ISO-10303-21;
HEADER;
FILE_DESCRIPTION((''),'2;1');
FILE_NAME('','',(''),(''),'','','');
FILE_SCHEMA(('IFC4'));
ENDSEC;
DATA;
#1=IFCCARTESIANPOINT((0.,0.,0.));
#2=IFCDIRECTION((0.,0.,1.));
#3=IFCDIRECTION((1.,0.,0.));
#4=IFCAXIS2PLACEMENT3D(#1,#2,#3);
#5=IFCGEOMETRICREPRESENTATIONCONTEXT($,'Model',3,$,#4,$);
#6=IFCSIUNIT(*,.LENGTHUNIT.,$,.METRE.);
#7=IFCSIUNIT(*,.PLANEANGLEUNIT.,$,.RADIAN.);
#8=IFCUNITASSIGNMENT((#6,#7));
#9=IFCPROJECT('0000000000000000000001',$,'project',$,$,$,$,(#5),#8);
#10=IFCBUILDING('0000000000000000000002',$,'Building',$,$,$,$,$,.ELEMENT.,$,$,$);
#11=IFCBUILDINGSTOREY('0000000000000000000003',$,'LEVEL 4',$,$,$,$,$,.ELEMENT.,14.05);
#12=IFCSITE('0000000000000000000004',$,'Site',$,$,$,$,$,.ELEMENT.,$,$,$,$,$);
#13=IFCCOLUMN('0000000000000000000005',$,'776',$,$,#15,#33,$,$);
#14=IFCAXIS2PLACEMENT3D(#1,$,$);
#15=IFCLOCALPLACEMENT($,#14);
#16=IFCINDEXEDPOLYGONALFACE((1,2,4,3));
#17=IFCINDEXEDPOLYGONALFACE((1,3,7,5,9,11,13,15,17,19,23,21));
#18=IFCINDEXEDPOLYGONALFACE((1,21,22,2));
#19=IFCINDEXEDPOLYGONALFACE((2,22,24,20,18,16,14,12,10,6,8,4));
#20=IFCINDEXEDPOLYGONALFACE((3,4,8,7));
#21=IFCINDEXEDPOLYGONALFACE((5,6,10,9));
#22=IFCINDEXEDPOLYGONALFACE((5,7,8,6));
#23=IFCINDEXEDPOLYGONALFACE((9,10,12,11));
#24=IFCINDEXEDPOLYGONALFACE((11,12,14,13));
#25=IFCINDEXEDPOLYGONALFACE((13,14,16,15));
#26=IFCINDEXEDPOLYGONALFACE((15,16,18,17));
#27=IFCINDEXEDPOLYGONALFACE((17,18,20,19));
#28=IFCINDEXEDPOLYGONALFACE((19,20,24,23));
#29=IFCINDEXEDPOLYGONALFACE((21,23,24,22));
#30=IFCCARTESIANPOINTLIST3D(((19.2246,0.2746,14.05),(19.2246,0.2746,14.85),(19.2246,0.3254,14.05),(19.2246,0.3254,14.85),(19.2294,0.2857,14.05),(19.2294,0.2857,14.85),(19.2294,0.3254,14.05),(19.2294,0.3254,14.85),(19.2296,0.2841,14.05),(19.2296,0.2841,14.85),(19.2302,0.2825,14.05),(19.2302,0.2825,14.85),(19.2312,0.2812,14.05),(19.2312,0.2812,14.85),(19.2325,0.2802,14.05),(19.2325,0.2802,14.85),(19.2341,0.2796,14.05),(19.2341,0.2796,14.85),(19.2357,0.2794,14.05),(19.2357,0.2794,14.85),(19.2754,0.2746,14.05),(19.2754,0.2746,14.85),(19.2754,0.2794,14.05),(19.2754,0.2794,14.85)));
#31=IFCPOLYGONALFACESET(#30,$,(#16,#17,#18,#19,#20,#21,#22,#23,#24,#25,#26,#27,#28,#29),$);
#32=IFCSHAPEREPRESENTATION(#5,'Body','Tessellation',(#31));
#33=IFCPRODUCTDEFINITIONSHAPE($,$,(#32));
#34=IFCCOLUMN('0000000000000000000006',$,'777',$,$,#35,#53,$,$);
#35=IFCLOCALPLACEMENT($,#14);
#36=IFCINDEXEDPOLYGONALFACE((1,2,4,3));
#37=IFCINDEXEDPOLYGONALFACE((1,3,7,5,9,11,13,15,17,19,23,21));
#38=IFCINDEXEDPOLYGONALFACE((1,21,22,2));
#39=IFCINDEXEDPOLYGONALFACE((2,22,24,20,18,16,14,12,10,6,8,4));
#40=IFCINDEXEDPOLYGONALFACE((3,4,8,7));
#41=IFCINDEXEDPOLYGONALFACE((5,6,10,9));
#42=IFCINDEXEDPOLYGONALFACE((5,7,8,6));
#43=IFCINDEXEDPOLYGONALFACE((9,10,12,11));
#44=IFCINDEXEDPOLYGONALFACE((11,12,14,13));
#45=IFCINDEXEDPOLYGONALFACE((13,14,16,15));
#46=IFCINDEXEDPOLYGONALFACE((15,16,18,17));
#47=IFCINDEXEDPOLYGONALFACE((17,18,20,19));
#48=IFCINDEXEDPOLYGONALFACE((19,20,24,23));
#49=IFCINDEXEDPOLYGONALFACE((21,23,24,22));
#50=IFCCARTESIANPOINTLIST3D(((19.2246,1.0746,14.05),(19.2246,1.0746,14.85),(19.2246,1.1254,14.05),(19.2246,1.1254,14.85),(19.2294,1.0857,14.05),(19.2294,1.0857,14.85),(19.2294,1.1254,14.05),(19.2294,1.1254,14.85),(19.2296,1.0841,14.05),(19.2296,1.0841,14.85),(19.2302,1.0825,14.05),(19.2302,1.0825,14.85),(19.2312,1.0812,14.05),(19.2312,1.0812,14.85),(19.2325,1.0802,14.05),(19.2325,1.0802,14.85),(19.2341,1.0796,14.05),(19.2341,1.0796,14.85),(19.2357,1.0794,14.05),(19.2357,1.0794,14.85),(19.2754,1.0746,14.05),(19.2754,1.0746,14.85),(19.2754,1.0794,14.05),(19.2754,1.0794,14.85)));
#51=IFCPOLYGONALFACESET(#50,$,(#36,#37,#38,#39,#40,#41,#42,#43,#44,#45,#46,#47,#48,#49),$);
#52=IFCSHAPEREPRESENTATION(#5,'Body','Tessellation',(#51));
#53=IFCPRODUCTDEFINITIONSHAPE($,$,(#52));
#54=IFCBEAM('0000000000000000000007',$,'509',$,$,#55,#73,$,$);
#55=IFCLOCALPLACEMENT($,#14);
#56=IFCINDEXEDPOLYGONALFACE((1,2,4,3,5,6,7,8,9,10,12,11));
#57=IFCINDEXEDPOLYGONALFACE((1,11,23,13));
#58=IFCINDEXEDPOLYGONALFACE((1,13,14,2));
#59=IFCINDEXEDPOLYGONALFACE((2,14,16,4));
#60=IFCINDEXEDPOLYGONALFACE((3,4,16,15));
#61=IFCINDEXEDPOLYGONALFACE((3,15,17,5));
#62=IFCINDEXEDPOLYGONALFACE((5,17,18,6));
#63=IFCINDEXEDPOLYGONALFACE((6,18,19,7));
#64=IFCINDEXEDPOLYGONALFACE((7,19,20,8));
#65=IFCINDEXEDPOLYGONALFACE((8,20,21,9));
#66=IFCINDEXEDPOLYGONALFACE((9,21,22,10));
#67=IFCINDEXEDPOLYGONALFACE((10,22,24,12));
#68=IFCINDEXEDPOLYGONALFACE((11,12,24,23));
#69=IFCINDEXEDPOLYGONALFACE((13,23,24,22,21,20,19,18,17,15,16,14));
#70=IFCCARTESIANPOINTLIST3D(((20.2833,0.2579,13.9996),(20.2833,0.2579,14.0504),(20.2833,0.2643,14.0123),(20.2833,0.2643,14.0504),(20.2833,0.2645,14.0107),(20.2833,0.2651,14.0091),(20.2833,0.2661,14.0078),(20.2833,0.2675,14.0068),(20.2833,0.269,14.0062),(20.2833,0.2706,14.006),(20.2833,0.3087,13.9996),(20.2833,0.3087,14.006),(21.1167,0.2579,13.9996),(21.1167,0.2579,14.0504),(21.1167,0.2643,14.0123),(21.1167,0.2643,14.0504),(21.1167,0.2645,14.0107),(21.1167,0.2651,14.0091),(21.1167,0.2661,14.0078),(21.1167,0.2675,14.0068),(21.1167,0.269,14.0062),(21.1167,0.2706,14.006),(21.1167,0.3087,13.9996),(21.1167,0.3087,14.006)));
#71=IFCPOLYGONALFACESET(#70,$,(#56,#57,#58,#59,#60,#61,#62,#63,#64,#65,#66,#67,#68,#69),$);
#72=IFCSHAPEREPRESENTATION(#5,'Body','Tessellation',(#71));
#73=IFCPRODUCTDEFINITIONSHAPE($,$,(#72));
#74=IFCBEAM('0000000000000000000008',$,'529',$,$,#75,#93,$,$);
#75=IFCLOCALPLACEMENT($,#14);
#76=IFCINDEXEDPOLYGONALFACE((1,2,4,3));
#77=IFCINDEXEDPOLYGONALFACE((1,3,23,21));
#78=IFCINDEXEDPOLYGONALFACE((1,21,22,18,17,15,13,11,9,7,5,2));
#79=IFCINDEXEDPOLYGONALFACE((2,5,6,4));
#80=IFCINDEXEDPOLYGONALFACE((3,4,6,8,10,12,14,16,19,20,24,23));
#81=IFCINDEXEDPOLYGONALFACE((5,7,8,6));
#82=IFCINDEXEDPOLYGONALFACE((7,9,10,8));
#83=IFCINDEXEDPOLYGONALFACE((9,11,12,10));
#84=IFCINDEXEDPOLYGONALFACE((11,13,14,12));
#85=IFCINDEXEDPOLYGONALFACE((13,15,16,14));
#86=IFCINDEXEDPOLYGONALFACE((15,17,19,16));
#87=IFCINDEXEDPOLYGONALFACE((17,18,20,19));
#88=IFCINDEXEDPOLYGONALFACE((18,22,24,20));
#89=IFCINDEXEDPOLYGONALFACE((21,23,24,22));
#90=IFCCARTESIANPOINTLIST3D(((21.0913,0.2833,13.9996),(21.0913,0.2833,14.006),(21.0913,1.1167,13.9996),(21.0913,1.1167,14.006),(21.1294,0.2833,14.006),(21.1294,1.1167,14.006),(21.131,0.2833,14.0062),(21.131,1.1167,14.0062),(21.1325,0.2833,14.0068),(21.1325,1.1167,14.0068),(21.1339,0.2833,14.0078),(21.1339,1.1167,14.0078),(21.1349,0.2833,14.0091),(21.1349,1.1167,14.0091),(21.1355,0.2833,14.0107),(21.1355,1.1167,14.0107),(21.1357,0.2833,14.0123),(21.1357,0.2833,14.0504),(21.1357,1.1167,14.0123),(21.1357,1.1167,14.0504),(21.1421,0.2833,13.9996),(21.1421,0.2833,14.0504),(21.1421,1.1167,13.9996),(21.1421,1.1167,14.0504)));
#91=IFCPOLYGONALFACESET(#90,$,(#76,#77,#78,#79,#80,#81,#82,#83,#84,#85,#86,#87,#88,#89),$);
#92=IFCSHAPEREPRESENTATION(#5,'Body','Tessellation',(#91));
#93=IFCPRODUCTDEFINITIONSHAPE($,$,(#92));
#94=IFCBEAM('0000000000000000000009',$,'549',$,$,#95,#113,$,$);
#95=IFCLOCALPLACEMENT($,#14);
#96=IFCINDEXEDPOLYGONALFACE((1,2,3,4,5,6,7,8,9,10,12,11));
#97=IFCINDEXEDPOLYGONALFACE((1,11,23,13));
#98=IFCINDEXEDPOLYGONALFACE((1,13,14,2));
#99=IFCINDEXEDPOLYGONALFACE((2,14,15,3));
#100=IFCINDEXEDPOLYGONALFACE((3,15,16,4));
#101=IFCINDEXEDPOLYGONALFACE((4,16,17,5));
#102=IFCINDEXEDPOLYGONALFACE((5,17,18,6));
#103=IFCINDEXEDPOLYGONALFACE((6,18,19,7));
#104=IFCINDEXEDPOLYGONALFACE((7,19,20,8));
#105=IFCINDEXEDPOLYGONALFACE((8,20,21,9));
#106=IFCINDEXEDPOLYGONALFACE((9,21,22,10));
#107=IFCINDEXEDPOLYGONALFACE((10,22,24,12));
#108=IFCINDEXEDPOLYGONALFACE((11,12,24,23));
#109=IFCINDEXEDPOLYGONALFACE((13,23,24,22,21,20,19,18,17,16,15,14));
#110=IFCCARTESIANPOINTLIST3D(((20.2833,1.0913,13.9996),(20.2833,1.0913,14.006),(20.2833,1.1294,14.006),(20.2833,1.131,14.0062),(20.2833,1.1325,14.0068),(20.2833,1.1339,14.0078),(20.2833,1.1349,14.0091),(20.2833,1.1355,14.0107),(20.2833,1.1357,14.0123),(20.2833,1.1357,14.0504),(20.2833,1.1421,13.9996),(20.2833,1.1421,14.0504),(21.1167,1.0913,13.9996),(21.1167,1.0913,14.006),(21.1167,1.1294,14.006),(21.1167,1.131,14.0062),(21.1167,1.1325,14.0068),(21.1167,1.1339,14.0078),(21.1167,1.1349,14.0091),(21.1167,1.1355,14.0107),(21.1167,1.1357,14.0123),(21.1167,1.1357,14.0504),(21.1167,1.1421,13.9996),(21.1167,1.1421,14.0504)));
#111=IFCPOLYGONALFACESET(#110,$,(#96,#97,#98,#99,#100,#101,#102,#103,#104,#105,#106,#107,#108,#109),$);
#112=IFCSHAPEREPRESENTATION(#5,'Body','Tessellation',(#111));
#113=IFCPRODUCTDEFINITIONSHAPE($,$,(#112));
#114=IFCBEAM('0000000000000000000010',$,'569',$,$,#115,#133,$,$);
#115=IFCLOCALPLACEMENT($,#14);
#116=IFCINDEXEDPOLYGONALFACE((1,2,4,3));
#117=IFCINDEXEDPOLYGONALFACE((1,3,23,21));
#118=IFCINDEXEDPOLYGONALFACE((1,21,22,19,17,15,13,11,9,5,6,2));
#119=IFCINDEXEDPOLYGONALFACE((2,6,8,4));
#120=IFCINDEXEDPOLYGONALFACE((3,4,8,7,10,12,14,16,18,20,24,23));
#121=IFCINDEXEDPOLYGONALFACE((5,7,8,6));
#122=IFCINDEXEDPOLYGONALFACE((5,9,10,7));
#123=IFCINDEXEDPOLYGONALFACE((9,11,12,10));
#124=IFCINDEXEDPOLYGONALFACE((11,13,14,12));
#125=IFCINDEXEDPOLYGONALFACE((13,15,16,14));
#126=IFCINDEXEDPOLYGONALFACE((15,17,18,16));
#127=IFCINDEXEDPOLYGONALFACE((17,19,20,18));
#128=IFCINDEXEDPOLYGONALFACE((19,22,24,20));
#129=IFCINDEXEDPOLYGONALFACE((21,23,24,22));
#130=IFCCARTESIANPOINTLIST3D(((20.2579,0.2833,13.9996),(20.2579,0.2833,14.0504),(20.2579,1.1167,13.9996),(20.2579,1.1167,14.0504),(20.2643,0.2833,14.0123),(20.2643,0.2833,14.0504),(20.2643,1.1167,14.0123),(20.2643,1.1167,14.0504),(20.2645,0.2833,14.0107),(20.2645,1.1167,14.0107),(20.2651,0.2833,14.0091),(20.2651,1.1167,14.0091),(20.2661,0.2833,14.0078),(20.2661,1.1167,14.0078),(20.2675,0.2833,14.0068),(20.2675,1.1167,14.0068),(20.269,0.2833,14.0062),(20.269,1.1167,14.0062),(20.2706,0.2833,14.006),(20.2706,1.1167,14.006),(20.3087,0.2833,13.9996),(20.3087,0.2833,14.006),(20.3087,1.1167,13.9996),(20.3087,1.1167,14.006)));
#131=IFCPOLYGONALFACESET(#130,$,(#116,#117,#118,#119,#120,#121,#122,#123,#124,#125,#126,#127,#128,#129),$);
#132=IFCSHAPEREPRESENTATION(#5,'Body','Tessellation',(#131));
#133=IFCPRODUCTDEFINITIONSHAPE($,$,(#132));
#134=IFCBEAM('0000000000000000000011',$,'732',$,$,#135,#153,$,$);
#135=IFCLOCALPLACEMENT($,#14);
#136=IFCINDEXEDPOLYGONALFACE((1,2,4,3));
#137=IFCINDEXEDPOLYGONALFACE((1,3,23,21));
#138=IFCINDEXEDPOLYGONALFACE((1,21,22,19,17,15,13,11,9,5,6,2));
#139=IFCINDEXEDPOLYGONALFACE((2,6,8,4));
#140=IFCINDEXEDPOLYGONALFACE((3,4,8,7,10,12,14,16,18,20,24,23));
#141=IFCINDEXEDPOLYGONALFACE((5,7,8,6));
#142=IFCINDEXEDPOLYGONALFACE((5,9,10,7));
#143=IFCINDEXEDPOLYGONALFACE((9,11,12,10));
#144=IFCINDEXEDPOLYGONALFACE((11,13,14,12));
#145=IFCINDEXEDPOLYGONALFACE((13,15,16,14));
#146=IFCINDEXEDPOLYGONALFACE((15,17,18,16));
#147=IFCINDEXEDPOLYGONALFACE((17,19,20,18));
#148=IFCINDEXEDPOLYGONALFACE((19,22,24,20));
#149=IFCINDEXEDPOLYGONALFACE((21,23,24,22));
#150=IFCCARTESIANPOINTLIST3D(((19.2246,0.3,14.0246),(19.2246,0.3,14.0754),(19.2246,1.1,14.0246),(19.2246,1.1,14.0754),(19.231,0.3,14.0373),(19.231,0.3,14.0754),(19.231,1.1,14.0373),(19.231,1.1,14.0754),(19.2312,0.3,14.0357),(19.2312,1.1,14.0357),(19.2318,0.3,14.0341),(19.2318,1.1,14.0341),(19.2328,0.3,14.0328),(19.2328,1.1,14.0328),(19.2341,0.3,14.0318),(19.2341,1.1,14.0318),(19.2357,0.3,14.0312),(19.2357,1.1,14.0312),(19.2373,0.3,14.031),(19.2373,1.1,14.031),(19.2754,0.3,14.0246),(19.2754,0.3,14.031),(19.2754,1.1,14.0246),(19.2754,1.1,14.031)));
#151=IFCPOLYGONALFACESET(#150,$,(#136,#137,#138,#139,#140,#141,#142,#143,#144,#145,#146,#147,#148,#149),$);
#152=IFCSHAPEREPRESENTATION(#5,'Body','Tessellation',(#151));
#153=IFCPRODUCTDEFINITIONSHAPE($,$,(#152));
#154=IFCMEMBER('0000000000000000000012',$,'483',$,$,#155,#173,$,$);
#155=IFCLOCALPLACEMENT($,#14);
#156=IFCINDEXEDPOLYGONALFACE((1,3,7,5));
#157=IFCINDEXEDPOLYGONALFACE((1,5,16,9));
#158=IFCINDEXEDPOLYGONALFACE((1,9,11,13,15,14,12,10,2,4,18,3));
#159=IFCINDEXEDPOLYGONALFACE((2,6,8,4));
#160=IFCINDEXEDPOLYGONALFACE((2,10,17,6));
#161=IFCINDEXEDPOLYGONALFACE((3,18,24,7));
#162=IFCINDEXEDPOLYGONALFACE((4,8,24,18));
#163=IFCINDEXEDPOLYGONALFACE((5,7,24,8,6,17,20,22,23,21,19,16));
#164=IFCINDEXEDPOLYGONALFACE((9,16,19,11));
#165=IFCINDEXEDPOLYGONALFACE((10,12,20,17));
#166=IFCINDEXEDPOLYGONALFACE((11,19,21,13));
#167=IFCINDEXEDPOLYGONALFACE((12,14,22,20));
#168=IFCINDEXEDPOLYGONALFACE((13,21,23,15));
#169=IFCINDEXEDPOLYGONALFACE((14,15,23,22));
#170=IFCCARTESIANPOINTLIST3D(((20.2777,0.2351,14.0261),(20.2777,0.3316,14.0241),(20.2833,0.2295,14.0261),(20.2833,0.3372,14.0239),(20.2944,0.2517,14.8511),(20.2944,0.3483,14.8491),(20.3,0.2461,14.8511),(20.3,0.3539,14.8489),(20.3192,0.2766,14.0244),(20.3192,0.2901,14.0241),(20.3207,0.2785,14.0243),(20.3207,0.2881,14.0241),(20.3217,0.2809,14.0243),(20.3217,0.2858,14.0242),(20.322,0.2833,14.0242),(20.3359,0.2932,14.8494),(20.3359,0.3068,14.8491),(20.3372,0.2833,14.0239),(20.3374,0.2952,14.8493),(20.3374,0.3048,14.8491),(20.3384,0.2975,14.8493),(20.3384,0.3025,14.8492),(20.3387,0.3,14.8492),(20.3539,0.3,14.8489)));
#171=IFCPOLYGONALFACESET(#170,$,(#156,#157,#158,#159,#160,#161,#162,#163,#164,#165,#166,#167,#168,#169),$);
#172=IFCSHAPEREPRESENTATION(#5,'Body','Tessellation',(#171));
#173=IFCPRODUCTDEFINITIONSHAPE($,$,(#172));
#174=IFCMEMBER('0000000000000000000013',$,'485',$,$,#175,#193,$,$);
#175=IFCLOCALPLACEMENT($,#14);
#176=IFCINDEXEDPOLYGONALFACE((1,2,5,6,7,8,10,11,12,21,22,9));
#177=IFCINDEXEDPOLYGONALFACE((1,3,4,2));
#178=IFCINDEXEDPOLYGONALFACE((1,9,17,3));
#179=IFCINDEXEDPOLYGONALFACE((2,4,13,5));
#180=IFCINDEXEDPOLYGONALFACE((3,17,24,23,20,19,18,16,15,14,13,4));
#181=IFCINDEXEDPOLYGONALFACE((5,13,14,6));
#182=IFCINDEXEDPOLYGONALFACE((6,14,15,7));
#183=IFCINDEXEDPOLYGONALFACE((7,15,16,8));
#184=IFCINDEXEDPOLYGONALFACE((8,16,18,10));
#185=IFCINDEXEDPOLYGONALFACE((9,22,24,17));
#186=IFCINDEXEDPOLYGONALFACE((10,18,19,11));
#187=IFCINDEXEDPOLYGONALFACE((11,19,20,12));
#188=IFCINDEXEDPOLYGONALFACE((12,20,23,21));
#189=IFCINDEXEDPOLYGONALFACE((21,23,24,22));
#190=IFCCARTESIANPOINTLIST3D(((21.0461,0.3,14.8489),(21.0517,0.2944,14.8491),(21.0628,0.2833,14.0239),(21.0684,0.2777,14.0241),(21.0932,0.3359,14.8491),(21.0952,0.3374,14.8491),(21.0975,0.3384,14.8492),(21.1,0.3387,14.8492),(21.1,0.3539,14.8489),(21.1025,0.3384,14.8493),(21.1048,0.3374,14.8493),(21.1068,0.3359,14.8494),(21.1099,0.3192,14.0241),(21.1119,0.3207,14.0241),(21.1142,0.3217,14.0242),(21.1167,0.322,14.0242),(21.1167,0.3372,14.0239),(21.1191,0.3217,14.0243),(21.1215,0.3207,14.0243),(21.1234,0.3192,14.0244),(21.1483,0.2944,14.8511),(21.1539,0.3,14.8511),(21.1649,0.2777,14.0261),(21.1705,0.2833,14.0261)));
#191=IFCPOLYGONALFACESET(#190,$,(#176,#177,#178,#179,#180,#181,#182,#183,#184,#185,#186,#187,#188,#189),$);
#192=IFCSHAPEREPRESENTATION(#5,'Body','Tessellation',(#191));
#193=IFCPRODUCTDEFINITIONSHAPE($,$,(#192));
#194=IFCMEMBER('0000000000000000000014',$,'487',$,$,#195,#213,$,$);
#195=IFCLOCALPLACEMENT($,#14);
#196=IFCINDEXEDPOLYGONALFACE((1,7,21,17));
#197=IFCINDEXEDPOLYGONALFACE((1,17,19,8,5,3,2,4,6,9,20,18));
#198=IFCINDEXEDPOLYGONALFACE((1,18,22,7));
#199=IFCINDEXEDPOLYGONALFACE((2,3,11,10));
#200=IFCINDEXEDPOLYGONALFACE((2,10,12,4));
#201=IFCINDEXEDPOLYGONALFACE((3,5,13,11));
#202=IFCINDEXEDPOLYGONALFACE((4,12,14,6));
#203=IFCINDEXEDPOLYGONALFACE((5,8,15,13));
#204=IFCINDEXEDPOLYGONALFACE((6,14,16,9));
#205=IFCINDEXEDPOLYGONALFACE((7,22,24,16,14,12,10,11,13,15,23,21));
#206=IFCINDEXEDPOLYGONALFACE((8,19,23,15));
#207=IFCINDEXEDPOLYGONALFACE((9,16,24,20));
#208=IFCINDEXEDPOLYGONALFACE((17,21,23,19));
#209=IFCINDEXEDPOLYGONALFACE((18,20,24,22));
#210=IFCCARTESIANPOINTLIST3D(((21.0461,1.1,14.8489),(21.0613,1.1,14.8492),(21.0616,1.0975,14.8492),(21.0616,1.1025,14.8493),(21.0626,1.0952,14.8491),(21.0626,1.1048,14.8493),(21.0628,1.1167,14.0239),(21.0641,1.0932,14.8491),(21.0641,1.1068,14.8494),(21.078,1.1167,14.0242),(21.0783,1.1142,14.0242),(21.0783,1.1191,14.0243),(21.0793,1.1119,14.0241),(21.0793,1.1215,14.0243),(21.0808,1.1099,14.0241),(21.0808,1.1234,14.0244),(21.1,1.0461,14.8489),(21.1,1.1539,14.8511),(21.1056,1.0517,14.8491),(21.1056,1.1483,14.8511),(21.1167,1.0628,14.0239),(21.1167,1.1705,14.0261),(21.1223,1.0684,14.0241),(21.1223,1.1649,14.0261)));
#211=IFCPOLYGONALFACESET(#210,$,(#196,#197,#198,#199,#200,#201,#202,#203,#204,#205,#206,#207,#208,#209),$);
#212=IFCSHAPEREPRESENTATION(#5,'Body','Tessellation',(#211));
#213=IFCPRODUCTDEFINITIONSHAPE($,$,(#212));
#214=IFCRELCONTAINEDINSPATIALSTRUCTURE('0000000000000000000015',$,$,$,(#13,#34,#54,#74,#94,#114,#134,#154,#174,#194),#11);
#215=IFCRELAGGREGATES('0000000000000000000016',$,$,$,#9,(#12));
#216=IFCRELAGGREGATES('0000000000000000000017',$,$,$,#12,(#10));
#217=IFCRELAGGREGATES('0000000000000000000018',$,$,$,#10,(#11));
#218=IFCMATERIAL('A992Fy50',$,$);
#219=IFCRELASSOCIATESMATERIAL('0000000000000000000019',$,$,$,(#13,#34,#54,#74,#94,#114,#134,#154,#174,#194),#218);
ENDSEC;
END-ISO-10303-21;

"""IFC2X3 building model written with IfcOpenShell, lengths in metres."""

from ifc_helpers import new_model, si_unit, frame, origin_with_axes, origin_2d_with_axis, place, context, project, spatial, l_section, extrude, material, element, save


model = new_model("IFC2X3")

# Units and contexts
model_context = context("Model", 3, world=origin_with_axes())
ifc_project = project(units=[si_unit("LENGTHUNIT", "METRE"), si_unit("PLANEANGLEUNIT", "RADIAN")], contexts=[model_context])

# Site, building, storey
site = spatial("IfcSite", under=ifc_project, Name="Site", CompositionType="ELEMENT")
building = spatial("IfcBuilding", under=site, Name="Building", CompositionType="ELEMENT")
storey = spatial("IfcBuildingStorey", under=building, Name="LEVEL 4", CompositionType="ELEMENT", Elevation=14.05)

# Columns
ifc_material = material(Name="A992Fy50")
for number, where, z_axis, x_axis, name in (
    (1, (19.25, 0.3, 14.85), (0.0, 0.0, -1.0), (0.0, 1.0, 0.0), "776"),
    (2, (19.25, 1.1, 14.85), (0.0, 0.0, -1.0), (0.0, 1.0, 0.0), "777"),
):
    element("IfcColumn", number, at=place(None, frame(where, z_axis=z_axis, x_axis=x_axis)), inside=storey, material=ifc_material, Name=name, context=model_context, shape_type="SweptSolid", body=[
        extrude(l_section(Depth=0.0508, Width=0.0508, Thickness=0.0048, FilletRadius=0.0063, at=origin_2d_with_axis()), origin_with_axes(), (0.0, 0.0, 1.0), 0.8),
    ])

# Beams
for number, where, z_axis, x_axis, name in (
    (3, (20.2833, 0.2833, 14.025), (1.0, 0.0, 0.0), (0.0, 1.0, 0.0), "509"),
    (4, (21.1167, 0.2833, 14.025), (0.0, 1.0, 0.0), (-1.0, 0.0, 0.0), "529"),
    (5, (21.1167, 1.1167, 14.025), (-1.0, 0.0, 0.0), (0.0, -1.0, 0.0), "549"),
    (6, (20.2833, 1.1167, 14.025), (0.0, -1.0, 0.0), (1.0, 0.0, 0.0), "569"),
):
    element("IfcBeam", number, at=place(None, frame(where, z_axis=z_axis, x_axis=x_axis)), inside=storey, material=ifc_material, Name=name, context=model_context, shape_type="SweptSolid", body=[
        extrude(l_section(Depth=0.0508, Width=0.0508, Thickness=0.0063, FilletRadius=0.0063, at=origin_2d_with_axis()), origin_with_axes(), (0.0, 0.0, 1.0), 0.8333),
    ])
beam_placement = place(None, frame((19.25, 1.1, 14.05), z_axis=(0.0, -1.0, 0.0), x_axis=(1.0, 0.0, 0.0)))
element("IfcBeam", 7, at=beam_placement, inside=storey, material=ifc_material, Name="732", context=model_context, shape_type="SweptSolid", body=[
    extrude(l_section(Depth=0.0508, Width=0.0508, Thickness=0.0063, FilletRadius=0.0063, at=origin_2d_with_axis()), origin_with_axes(), (0.0, 0.0, 1.0), 0.8),
])

# Members
for number, where, z_axis, x_axis, name in (
    (8, (20.2833, 0.2833, 14.025), (0.020194, 0.020194, 0.999592), (-0.707107, 0.707107, 0.0), "483"),
    (9, (21.1167, 0.2833, 14.025), (-0.020194, 0.020194, 0.999592), (-0.707107, -0.707107, 0.0), "485"),
    (10, (21.1167, 1.1167, 14.025), (-0.020194, -0.020194, 0.999592), (0.707107, -0.707107, 0.0), "487"),
):
    element("IfcMember", number, at=place(None, frame(where, z_axis=z_axis, x_axis=x_axis)), inside=storey, material=ifc_material, Name=name, context=model_context, shape_type="SweptSolid", body=[
        extrude(l_section(Depth=0.0762, Width=0.0762, Thickness=0.0079, FilletRadius=0.0096, at=origin_2d_with_axis()), origin_with_axes(), (0.0, 0.0, 1.0), 0.8253),
    ])

save(model, "model.ifc")
